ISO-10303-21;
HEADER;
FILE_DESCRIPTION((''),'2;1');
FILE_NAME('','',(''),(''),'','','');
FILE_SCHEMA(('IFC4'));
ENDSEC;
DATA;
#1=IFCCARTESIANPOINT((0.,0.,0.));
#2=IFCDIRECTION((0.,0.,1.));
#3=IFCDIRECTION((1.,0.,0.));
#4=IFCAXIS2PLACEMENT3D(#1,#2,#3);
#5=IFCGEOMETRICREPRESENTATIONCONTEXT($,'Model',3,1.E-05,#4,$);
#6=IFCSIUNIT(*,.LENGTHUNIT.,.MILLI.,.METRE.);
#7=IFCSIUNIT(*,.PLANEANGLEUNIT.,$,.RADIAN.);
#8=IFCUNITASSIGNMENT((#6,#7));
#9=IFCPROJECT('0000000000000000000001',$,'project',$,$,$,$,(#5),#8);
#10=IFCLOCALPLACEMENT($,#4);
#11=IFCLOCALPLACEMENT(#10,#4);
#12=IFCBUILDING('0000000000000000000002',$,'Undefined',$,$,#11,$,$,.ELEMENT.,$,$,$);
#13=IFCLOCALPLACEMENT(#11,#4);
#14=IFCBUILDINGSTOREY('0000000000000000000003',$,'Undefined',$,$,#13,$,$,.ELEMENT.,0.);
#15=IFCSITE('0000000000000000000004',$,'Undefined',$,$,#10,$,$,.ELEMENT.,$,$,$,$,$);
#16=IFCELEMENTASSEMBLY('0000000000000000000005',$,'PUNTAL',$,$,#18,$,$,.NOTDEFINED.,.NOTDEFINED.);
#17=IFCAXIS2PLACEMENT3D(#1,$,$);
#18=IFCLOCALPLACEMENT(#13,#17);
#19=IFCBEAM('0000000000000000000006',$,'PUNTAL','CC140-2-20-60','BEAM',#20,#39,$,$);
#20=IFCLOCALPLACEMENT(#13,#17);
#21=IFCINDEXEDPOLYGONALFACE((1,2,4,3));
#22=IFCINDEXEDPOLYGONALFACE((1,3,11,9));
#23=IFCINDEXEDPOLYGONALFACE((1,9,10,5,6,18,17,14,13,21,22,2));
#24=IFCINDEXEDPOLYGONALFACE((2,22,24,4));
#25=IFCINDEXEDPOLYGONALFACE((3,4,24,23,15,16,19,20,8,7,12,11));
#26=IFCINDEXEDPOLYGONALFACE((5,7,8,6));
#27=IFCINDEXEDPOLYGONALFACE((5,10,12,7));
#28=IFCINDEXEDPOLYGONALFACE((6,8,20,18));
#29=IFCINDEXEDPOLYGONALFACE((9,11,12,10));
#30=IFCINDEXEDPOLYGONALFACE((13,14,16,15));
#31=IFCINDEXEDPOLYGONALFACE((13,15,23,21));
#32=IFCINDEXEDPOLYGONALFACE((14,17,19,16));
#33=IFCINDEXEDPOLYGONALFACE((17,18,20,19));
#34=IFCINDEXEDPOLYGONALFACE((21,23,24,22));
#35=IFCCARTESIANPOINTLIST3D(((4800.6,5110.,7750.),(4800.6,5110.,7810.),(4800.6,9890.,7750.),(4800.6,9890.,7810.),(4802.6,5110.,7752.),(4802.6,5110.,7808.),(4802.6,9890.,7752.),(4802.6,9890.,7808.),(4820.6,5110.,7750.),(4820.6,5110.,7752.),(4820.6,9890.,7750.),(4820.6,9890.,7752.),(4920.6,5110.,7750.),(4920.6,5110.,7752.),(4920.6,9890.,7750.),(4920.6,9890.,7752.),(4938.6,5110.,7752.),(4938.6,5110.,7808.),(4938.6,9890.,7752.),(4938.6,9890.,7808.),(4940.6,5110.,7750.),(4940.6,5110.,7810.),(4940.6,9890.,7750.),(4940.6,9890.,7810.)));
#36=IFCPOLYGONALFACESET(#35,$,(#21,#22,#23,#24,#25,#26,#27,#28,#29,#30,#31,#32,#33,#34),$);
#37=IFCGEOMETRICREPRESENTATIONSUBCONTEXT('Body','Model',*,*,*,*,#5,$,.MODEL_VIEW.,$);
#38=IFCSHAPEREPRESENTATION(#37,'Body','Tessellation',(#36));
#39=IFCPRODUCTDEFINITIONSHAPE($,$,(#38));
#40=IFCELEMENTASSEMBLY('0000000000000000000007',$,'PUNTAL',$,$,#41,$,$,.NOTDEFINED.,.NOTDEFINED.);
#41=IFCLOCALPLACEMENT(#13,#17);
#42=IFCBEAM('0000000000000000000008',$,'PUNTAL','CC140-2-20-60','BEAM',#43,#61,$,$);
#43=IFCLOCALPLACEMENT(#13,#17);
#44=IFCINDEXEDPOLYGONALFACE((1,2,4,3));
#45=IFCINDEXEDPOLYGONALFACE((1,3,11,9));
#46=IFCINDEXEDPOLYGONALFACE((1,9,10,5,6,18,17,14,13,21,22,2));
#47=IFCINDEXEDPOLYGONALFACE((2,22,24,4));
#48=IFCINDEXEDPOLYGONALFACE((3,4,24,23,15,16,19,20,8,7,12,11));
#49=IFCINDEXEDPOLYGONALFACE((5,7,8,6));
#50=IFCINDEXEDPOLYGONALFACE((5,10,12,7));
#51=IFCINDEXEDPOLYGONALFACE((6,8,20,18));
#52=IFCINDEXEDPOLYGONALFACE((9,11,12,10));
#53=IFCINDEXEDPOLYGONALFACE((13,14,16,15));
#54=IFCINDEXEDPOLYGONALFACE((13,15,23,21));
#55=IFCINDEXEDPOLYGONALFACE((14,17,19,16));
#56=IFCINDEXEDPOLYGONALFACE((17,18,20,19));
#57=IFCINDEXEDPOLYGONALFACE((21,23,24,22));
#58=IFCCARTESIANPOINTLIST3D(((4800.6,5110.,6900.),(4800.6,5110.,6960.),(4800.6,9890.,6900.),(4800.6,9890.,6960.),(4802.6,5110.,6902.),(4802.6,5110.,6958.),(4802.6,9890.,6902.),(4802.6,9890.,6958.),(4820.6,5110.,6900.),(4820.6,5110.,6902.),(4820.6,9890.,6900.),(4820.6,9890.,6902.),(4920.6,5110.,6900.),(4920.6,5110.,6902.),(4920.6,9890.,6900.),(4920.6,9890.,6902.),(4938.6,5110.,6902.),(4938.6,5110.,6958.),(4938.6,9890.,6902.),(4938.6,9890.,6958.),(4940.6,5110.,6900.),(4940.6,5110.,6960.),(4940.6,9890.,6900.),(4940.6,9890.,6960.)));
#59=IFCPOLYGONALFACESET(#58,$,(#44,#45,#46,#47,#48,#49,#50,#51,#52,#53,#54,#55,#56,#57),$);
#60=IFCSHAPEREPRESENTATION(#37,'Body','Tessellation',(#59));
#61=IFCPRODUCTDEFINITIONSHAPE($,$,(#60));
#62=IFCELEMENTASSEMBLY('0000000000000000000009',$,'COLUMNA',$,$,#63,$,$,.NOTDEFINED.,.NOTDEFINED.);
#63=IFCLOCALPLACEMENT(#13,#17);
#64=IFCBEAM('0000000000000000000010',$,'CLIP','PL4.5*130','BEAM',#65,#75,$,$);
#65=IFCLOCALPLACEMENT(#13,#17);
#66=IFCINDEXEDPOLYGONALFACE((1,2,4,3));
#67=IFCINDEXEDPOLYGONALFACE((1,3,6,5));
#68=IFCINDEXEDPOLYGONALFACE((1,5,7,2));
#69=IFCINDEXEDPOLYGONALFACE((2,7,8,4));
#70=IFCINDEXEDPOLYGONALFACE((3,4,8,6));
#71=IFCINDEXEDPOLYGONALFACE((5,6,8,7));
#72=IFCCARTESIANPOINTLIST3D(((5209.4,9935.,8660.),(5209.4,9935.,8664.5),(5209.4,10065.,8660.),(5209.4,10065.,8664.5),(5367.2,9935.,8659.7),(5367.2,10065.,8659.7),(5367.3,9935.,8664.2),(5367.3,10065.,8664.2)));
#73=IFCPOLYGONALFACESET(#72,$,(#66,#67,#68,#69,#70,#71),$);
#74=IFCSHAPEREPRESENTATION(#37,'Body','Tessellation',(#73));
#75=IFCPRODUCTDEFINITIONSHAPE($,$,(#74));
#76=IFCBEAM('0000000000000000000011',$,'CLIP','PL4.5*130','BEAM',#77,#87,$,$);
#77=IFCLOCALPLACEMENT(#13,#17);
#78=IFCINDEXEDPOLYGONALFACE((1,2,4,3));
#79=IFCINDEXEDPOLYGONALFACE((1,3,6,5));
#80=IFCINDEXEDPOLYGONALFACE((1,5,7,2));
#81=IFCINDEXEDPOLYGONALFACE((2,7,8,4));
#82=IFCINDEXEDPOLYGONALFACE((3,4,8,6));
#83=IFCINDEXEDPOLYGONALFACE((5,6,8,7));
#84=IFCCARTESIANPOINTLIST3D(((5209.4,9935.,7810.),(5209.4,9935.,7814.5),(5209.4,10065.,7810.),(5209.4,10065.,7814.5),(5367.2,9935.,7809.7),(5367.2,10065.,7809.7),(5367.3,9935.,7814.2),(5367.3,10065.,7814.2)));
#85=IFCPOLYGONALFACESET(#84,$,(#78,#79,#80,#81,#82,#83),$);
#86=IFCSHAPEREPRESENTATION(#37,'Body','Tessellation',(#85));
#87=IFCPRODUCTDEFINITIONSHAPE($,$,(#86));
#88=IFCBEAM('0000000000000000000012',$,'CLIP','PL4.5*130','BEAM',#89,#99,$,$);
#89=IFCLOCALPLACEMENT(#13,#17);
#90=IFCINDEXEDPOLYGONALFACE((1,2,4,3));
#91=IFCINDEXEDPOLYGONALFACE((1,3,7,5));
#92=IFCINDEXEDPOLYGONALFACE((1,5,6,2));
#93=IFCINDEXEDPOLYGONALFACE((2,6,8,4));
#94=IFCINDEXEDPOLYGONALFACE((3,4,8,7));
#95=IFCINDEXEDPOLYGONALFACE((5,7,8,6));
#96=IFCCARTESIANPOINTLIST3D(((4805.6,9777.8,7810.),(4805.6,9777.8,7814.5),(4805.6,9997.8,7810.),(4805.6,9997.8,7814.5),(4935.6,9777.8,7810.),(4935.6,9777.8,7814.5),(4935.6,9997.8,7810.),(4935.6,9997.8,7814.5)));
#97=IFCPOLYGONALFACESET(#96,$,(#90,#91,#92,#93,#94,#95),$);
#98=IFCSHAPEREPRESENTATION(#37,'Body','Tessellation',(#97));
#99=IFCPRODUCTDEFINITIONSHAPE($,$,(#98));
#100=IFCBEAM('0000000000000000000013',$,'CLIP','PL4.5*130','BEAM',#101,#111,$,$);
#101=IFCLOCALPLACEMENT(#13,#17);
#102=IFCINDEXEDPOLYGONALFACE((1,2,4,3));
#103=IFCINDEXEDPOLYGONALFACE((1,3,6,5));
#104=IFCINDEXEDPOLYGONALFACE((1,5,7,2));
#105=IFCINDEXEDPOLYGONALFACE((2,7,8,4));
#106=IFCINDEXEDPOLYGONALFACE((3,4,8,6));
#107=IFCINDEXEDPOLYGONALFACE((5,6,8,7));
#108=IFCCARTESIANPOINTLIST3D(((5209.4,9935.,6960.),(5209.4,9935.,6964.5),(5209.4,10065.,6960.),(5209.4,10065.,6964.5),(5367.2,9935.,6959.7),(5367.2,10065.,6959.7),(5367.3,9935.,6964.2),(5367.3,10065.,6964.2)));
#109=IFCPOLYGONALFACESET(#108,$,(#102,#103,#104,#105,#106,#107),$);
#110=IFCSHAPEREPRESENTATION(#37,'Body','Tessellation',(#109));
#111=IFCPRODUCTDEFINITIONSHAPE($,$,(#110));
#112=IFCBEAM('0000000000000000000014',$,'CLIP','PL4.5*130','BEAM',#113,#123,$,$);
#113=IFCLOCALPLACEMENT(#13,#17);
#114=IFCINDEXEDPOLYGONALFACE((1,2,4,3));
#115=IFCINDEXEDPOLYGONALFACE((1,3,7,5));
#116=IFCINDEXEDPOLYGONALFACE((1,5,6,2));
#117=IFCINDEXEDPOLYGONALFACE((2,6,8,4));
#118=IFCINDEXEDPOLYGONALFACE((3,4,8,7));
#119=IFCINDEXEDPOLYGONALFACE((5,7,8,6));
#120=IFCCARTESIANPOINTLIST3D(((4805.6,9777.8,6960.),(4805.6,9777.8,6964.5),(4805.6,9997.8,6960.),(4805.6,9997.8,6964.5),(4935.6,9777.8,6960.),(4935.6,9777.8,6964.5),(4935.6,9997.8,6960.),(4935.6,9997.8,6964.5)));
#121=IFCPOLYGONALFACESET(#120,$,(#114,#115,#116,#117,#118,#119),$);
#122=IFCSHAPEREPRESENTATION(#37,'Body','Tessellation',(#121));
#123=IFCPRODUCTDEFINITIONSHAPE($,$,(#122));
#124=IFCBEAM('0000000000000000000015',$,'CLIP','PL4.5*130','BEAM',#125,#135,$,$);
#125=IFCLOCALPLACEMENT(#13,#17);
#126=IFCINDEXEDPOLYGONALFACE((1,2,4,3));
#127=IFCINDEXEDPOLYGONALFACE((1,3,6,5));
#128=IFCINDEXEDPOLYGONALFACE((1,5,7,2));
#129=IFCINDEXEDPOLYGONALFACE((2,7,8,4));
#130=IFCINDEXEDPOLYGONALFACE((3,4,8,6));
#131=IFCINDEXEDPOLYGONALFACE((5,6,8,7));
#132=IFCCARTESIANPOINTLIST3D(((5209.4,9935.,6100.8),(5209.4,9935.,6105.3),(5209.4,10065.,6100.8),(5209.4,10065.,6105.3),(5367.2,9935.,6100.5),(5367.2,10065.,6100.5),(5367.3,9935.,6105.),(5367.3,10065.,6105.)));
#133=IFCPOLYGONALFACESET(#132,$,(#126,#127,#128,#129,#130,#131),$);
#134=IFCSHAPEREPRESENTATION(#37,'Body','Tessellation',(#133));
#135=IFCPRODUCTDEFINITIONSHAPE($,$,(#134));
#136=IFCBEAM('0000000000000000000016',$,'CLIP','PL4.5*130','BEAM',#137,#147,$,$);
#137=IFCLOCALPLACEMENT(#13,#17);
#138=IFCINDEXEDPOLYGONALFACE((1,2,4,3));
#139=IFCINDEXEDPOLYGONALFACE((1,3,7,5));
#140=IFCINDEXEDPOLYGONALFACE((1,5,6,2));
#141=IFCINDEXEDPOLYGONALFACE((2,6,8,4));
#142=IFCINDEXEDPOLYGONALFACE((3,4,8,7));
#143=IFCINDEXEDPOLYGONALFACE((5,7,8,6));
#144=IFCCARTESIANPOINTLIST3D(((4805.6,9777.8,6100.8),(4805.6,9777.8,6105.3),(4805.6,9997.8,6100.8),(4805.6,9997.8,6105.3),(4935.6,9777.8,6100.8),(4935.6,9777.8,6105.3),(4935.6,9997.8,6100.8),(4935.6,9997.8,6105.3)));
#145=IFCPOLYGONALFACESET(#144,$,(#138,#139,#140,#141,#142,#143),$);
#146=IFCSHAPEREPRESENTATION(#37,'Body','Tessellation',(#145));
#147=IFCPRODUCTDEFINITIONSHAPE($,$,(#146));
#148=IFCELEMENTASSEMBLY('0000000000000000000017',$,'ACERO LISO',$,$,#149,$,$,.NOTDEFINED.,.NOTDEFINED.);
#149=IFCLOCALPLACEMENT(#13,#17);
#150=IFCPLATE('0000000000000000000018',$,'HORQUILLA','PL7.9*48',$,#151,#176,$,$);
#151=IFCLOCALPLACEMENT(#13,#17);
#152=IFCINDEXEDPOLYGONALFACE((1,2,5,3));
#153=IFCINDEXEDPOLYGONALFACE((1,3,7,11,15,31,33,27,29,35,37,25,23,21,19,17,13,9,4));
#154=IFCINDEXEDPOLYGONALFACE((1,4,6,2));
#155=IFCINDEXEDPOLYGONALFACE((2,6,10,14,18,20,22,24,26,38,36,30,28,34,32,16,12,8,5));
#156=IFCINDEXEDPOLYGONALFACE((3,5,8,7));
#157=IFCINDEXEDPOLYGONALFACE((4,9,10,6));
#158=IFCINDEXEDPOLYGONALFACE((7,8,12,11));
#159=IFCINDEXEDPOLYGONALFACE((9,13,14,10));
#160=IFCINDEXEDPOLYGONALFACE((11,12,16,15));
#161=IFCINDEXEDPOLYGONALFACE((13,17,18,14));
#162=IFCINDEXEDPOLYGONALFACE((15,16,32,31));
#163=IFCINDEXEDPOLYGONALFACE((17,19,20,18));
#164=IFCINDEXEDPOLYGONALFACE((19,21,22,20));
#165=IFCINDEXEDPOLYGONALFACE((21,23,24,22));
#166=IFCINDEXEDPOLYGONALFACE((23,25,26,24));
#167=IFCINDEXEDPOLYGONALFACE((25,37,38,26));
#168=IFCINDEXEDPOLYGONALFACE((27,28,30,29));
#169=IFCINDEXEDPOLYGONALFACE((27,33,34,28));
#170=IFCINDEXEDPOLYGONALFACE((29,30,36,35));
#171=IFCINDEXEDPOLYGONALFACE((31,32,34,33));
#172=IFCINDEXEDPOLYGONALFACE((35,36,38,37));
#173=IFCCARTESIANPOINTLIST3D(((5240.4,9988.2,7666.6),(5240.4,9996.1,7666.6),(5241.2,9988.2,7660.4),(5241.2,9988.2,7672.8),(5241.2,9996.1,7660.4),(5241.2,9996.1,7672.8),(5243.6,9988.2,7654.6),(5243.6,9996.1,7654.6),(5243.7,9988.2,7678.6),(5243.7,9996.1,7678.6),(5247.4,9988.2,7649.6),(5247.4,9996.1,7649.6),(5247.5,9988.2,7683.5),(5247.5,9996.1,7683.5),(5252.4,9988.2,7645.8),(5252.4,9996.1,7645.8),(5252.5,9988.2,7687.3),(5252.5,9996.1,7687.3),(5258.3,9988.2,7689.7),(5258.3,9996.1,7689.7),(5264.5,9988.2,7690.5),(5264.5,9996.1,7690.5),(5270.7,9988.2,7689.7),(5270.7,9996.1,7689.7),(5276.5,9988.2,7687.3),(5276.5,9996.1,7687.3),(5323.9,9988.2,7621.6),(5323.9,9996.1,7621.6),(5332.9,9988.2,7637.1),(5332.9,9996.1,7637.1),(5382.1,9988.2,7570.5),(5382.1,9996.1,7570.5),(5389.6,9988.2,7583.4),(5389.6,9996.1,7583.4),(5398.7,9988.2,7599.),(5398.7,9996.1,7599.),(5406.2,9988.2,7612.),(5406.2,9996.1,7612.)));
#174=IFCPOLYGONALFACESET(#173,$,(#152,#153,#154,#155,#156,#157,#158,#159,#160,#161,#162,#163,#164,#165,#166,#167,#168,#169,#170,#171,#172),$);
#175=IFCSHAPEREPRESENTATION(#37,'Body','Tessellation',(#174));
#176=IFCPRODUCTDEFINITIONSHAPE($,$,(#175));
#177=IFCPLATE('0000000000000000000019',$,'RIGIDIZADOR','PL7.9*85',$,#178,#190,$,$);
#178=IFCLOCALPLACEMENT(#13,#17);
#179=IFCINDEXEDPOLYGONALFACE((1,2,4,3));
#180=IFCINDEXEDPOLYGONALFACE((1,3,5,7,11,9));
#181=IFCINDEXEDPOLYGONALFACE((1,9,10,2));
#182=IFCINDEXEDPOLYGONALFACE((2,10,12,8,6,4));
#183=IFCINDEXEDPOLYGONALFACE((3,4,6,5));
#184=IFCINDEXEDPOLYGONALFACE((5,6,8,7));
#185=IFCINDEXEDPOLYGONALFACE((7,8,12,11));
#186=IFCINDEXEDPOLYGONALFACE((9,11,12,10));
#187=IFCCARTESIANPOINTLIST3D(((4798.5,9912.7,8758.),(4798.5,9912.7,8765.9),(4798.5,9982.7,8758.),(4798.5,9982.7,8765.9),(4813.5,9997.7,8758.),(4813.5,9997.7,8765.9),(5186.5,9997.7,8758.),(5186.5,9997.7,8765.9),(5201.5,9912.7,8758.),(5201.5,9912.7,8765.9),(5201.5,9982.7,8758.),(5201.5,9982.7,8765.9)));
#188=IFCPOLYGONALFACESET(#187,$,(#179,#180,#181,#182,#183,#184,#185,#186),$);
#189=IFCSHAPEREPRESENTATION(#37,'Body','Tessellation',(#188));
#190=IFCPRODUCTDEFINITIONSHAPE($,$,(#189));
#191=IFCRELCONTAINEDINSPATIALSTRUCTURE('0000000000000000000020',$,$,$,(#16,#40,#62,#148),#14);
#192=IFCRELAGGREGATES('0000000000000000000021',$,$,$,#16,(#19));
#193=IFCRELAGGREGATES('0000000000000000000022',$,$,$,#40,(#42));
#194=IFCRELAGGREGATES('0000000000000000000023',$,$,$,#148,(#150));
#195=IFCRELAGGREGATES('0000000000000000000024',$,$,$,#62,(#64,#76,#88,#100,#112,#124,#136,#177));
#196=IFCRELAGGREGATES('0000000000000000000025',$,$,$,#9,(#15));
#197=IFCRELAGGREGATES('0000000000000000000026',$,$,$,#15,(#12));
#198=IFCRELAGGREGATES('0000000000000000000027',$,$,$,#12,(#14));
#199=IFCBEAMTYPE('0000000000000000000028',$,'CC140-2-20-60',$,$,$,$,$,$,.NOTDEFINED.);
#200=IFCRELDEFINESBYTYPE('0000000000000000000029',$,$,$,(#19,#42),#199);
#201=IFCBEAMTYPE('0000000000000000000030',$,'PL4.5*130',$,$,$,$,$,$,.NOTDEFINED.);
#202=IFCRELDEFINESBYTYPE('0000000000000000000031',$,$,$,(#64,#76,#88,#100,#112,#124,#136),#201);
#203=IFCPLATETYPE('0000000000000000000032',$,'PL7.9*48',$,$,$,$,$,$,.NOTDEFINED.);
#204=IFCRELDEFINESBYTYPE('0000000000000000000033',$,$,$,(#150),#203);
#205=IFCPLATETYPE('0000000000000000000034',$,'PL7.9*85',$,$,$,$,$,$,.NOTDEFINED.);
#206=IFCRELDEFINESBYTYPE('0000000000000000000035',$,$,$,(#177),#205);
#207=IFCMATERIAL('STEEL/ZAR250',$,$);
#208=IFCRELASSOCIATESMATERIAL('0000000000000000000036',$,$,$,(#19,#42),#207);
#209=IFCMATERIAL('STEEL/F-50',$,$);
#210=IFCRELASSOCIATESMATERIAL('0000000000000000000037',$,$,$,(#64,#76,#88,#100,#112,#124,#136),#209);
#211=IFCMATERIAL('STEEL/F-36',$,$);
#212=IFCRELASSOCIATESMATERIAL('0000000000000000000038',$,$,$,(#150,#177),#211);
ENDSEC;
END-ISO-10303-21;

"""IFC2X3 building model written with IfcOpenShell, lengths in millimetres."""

from ifc_helpers import new_model, si_unit, frame, origin_with_axes, origin_2d_with_axis, place, context, subcontext, project, spatial, polyline, rectangle, c_section, outline, extrude, boolean, material, type_object, element, aggregate, save


model = new_model("IFC2X3")

# Units and contexts
model_context = context("Model", 3, precision=1e-05, world=origin_with_axes())
body_context = subcontext(model_context, "Body", "Model", "MODEL_VIEW")
ifc_project = project(units=[si_unit("LENGTHUNIT", "METRE", prefix="MILLI"), si_unit("PLANEANGLEUNIT", "RADIAN")], contexts=[model_context])

# Site, building, storey
site_placement = place(None, origin_with_axes())
site = spatial("IfcSite", under=ifc_project, at=site_placement, Name="Undefined", CompositionType="ELEMENT")
building_placement = place(site_placement, origin_with_axes())
building = spatial("IfcBuilding", under=site, at=building_placement, Name="Undefined", CompositionType="ELEMENT")
storey_placement = place(building_placement, origin_with_axes())
storey = spatial("IfcBuildingStorey", under=building, at=storey_placement, Name="Undefined", CompositionType="ELEMENT", Elevation=0.0)

# Element assemblies, beams
assembly_1_placement = place(storey_placement, origin_with_axes())
assembly_1 = element("IfcElementAssembly", 1, at=assembly_1_placement, inside=storey, Name="PUNTAL", AssemblyPlace="NOTDEFINED", PredefinedType="NOTDEFINED")
ifc_material_1 = material(Name="STEEL/ZAR250")
beam_type_1 = type_object("IfcBeamType", Name="CC140-2-20-60", PredefinedType="NOTDEFINED")
beam_1_placement = place(assembly_1_placement, frame((4870.6, 9890.0, 7780.0), z_axis=(-1.0, 0.0, 0.0), x_axis=(0.0, -1.0, 0.0)))
beam_1 = element("IfcBeam", 2, at=beam_1_placement, type_object=beam_type_1, material=ifc_material_1, Name="PUNTAL", Description="CC140-2-20-60", ObjectType="BEAM", context=body_context, shape_type="SweptSolid", body=[
    extrude(c_section(Depth=140.0, Width=60.0, WallThickness=2.0, Girth=20.0, at=origin_2d_with_axis()), frame((4780.0, 0.0, 0.0), z_axis=(-1.0, 0.0, 0.0), x_axis=(0.0, -1.0, 0.0)), (0.0, 0.0, 1.0), 4780.0),
])
aggregate(assembly_1, [beam_1])
assembly_2_placement = place(storey_placement, origin_with_axes())
assembly_2 = element("IfcElementAssembly", 3, at=assembly_2_placement, inside=storey, Name="PUNTAL", AssemblyPlace="NOTDEFINED", PredefinedType="NOTDEFINED")
beam_2_placement = place(assembly_2_placement, frame((4870.6, 9890.0, 6930.0), z_axis=(-1.0, 0.0, 0.0), x_axis=(0.0, -1.0, 0.0)))
beam_2 = element("IfcBeam", 4, at=beam_2_placement, type_object=beam_type_1, material=ifc_material_1, Name="PUNTAL", Description="CC140-2-20-60", ObjectType="BEAM", context=body_context, shape_type="SweptSolid", body=[
    extrude(c_section(Depth=140.0, Width=60.0, WallThickness=2.0, Girth=20.0, at=origin_2d_with_axis()), frame((4780.0, 0.0, 0.0), z_axis=(-1.0, 0.0, 0.0), x_axis=(0.0, -1.0, 0.0)), (0.0, 0.0, 1.0), 4780.0),
])
aggregate(assembly_2, [beam_2])

# Element assembly, beams
assembly_3_placement = place(storey_placement, origin_with_axes())
assembly_3 = element("IfcElementAssembly", 5, at=assembly_3_placement, inside=storey, Name="COLUMNA", AssemblyPlace="NOTDEFINED", PredefinedType="NOTDEFINED")
ifc_material_2 = material(Name="STEEL/F-50")
beam_type_2 = type_object("IfcBeamType", Name="PL4.5*130", PredefinedType="NOTDEFINED")
beam_3_placement = place(assembly_3_placement, frame((5209.4, 10000.0, 8662.2), z_axis=(0.000009, -1.0, 0.0), x_axis=(0.999998, 0.000008, -0.001964)))
beam_3 = element("IfcBeam", 6, at=beam_3_placement, type_object=beam_type_2, material=ifc_material_2, Name="CLIP", Description="PL4.5*130", ObjectType="BEAM", context=body_context, shape_type="SweptSolid", body=[
    extrude(rectangle(XDim=4.5, YDim=130.0, at=origin_2d_with_axis()), frame((157.9, 0.0, 0.0), z_axis=(-1.0, 0.0, 0.0), x_axis=(0.0, -1.0, 0.0)), (0.0, 0.0, 1.0), 157.8),
])
beam_4_placement = place(assembly_3_placement, frame((5209.4, 10000.0, 7812.2), z_axis=(0.000009, -1.0, 0.0), x_axis=(0.999998, 0.000008, -0.001964)))
beam_4 = element("IfcBeam", 7, at=beam_4_placement, type_object=beam_type_2, material=ifc_material_2, Name="CLIP", Description="PL4.5*130", ObjectType="BEAM", context=body_context, shape_type="SweptSolid", body=[
    extrude(rectangle(XDim=4.5, YDim=130.0, at=origin_2d_with_axis()), frame((157.9, 0.0, 0.0), z_axis=(-1.0, 0.0, 0.0), x_axis=(0.0, -1.0, 0.0)), (0.0, 0.0, 1.0), 157.8),
])
beam_5_placement = place(assembly_3_placement, frame((4870.6, 9997.8, 7812.2), z_axis=(-1.0, -0.000006, 0.0), x_axis=(0.000006, -1.0, 0.0)))
beam_5 = element("IfcBeam", 8, at=beam_5_placement, type_object=beam_type_2, material=ifc_material_2, Name="CLIP", Description="PL4.5*130", ObjectType="BEAM", context=body_context, shape_type="SweptSolid", body=[
    extrude(rectangle(XDim=4.5, YDim=130.0, at=origin_2d_with_axis()), frame((220.0, 0.0, 0.0), z_axis=(-1.0, 0.0, 0.0), x_axis=(0.0, -1.0, 0.0)), (0.0, 0.0, 1.0), 220.0),
])
beam_6_placement = place(assembly_3_placement, frame((5209.4, 10000.0, 6962.2), z_axis=(0.000009, -1.0, 0.0), x_axis=(0.999998, 0.000008, -0.001964)))
beam_6 = element("IfcBeam", 9, at=beam_6_placement, type_object=beam_type_2, material=ifc_material_2, Name="CLIP", Description="PL4.5*130", ObjectType="BEAM", context=body_context, shape_type="SweptSolid", body=[
    extrude(rectangle(XDim=4.5, YDim=130.0, at=origin_2d_with_axis()), frame((157.9, 0.0, 0.0), z_axis=(-1.0, 0.0, 0.0), x_axis=(0.0, -1.0, 0.0)), (0.0, 0.0, 1.0), 157.8),
])
beam_7_placement = place(assembly_3_placement, frame((4870.6, 9997.8, 6962.2), z_axis=(-1.0, -0.000006, 0.0), x_axis=(0.000006, -1.0, 0.0)))
beam_7 = element("IfcBeam", 10, at=beam_7_placement, type_object=beam_type_2, material=ifc_material_2, Name="CLIP", Description="PL4.5*130", ObjectType="BEAM", context=body_context, shape_type="SweptSolid", body=[
    extrude(rectangle(XDim=4.5, YDim=130.0, at=origin_2d_with_axis()), frame((220.0, 0.0, 0.0), z_axis=(-1.0, 0.0, 0.0), x_axis=(0.0, -1.0, 0.0)), (0.0, 0.0, 1.0), 220.0),
])
beam_8_placement = place(assembly_3_placement, frame((5209.4, 10000.0, 6103.1), z_axis=(0.000009, -1.0, 0.0), x_axis=(0.999998, 0.000008, -0.001964)))
beam_8 = element("IfcBeam", 11, at=beam_8_placement, type_object=beam_type_2, material=ifc_material_2, Name="CLIP", Description="PL4.5*130", ObjectType="BEAM", context=body_context, shape_type="SweptSolid", body=[
    extrude(rectangle(XDim=4.5, YDim=130.0, at=origin_2d_with_axis()), frame((157.9, 0.0, 0.0), z_axis=(-1.0, 0.0, 0.0), x_axis=(0.0, -1.0, 0.0)), (0.0, 0.0, 1.0), 157.8),
])
beam_9_placement = place(assembly_3_placement, frame((4870.6, 9997.8, 6103.1), z_axis=(-1.0, -0.000006, 0.0), x_axis=(0.000006, -1.0, 0.0)))
beam_9 = element("IfcBeam", 12, at=beam_9_placement, type_object=beam_type_2, material=ifc_material_2, Name="CLIP", Description="PL4.5*130", ObjectType="BEAM", context=body_context, shape_type="SweptSolid", body=[
    extrude(rectangle(XDim=4.5, YDim=130.0, at=origin_2d_with_axis()), frame((220.0, 0.0, 0.0), z_axis=(-1.0, 0.0, 0.0), x_axis=(0.0, -1.0, 0.0)), (0.0, 0.0, 1.0), 220.0),
])

# Shared definitions
ifc_material_3 = material(Name="STEEL/F-36")

# Element assembly, plate
assembly_4_placement = place(storey_placement, origin_with_axes())
assembly_4 = element("IfcElementAssembly", 13, at=assembly_4_placement, inside=storey, Name="ACERO LISO", AssemblyPlace="NOTDEFINED", PredefinedType="NOTDEFINED")
plate_type_1 = type_object("IfcPlateType", Name="PL7.9*48", PredefinedType="NOTDEFINED")
plate_1_placement = place(assembly_4_placement, frame((5231.6, 9992.1, 7657.8), z_axis=(0.0, 1.0, 0.0), x_axis=(0.502021, 0.0, 0.864855)))
plate_1 = element("IfcPlate", 14, at=plate_1_placement, type_object=plate_type_1, material=ifc_material_3, Name="HORQUILLA", Description="PL7.9*48", context=body_context, shape_type="CSG", body=[
    boolean("DIFFERENCE", extrude(outline(polyline([(0.0, 24.0), (0.8, 17.8), (3.2, 12.0), (7.0, 7.0), (12.0, 3.2), (17.8, 0.8), (24.0, 0.0), (24.0, 0.0), (30.2, 0.8), (36.0, 3.2), (41.0, 7.0), (44.8, 12.0), (47.2, 17.8), (48.0, 24.0), (48.0, 174.0), (0.0, 174.0), (0.0, 24.0)])), frame((0.0, 0.0, -4.0), z_axis=(0.0, 0.0, 1.0), x_axis=(1.0, 0.0, 0.0)), (0.0, 0.0, 1.0), 7.9), extrude(rectangle(XDim=18.0, YDim=18.0, at=origin_2d_with_axis()), frame((24.0, 274.0, 0.0), z_axis=(0.0, -1.0, 0.0), x_axis=(0.0, 0.0, -1.0)), (0.0, 0.0, 1.0), 176.0)),
])
aggregate(assembly_4, [plate_1])

# Plate
plate_type_2 = type_object("IfcPlateType", Name="PL7.9*85", PredefinedType="NOTDEFINED")
plate_2_placement = place(assembly_3_placement, frame((5201.5, 9997.7, 8761.9), z_axis=(0.0, 0.0, -1.0), x_axis=(0.0, -1.0, 0.0)))
plate_2 = element("IfcPlate", 15, at=plate_2_placement, type_object=plate_type_2, material=ifc_material_3, Name="RIGIDIZADOR", Description="PL7.9*85", context=body_context, shape_type="SweptSolid", body=[
    extrude(outline(polyline([(0.0, 15.0), (15.0, 0.0), (85.0, 0.0), (85.0, 403.0), (15.0, 403.0), (0.0, 388.0), (0.0, 15.0)])), frame((0.0, 0.0, -4.0), z_axis=(0.0, 0.0, 1.0), x_axis=(1.0, 0.0, 0.0)), (0.0, 0.0, 1.0), 7.9),
])
aggregate(assembly_3, [beam_3, beam_4, beam_5, beam_6, beam_7, beam_8, beam_9, plate_2])

save(model, "model.ifc")
